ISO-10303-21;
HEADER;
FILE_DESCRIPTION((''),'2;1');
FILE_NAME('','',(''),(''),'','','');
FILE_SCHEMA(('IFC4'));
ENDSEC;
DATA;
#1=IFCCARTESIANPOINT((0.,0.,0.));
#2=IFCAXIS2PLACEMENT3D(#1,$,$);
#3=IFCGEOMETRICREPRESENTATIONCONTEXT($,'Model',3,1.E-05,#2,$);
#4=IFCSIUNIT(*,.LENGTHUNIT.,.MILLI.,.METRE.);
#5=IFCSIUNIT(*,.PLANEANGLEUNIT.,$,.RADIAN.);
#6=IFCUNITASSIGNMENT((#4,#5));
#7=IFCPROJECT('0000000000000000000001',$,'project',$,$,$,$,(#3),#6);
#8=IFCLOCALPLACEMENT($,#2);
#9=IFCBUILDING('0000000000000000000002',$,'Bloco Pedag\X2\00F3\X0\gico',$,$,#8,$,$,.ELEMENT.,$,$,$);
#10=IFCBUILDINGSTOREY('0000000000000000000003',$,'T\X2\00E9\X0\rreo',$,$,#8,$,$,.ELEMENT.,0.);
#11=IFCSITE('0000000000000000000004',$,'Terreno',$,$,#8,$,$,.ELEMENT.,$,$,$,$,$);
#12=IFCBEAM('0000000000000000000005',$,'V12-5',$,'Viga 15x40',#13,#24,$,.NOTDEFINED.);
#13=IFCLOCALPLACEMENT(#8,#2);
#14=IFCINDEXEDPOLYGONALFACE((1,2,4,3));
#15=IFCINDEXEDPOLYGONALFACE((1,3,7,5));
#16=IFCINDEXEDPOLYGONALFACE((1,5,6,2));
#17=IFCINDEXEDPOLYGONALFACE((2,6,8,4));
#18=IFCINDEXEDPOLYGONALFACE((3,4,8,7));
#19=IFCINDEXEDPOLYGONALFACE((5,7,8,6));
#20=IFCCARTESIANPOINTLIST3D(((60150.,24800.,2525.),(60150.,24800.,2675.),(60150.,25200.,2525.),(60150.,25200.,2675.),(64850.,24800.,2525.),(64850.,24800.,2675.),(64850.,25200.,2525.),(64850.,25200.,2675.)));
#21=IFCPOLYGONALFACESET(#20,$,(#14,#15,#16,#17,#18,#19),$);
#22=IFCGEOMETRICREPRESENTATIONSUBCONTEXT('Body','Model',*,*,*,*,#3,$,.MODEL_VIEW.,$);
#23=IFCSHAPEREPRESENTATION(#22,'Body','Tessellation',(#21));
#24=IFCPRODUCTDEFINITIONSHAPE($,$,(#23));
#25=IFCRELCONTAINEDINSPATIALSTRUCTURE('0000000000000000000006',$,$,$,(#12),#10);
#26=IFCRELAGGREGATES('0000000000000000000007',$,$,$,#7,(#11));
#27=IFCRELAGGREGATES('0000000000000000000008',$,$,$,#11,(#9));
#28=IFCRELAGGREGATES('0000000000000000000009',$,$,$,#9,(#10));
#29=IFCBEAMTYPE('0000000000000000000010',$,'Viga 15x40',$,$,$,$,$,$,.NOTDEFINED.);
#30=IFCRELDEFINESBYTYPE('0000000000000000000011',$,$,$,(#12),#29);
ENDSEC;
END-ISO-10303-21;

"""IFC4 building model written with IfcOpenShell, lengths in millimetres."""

from ifc_helpers import new_model, si_unit, frame, origin, origin_2d, place, context, subcontext, project, spatial, rectangle, extrude, type_object, element, save


model = new_model("IFC4")

# Units and contexts
model_context = context("Model", 3, precision=1e-05, world=origin())
body_context = subcontext(model_context, "Body", "Model", "MODEL_VIEW")
ifc_project = project(units=[si_unit("LENGTHUNIT", "METRE", prefix="MILLI"), si_unit("PLANEANGLEUNIT", "RADIAN")], contexts=[model_context])

# Site, building, storey
placement = place(None, origin())
site = spatial("IfcSite", under=ifc_project, at=placement, Name="Terreno", CompositionType="ELEMENT")
building = spatial("IfcBuilding", under=site, at=placement, Name="Bloco Pedagógico", CompositionType="ELEMENT")
storey = spatial("IfcBuildingStorey", under=building, at=placement, Name="Térreo", CompositionType="ELEMENT", Elevation=0.0)

# Beam
beam_type = type_object("IfcBeamType", Name="Viga 15x40", PredefinedType="NOTDEFINED")
for number, where, z_axis, x_axis, name in (
    (1, (60150.0, 25000.0, 2600.0), (1.0, 0.0, 0.0), (0.0, 1.0, 0.0), "V12-5"),
):
    element("IfcBeam", number, at=place(None, frame(where, z_axis=z_axis, x_axis=x_axis)), inside=storey, type_object=beam_type, Name=name, ObjectType="Viga 15x40", PredefinedType="NOTDEFINED", context=body_context, shape_type="SweptSolid", body=[
        extrude(rectangle(XDim=400.0, YDim=150.0, at=origin_2d()), None, (0.0, 0.0, 1.0), 4700.0),
    ])

save(model, "model.ifc")
